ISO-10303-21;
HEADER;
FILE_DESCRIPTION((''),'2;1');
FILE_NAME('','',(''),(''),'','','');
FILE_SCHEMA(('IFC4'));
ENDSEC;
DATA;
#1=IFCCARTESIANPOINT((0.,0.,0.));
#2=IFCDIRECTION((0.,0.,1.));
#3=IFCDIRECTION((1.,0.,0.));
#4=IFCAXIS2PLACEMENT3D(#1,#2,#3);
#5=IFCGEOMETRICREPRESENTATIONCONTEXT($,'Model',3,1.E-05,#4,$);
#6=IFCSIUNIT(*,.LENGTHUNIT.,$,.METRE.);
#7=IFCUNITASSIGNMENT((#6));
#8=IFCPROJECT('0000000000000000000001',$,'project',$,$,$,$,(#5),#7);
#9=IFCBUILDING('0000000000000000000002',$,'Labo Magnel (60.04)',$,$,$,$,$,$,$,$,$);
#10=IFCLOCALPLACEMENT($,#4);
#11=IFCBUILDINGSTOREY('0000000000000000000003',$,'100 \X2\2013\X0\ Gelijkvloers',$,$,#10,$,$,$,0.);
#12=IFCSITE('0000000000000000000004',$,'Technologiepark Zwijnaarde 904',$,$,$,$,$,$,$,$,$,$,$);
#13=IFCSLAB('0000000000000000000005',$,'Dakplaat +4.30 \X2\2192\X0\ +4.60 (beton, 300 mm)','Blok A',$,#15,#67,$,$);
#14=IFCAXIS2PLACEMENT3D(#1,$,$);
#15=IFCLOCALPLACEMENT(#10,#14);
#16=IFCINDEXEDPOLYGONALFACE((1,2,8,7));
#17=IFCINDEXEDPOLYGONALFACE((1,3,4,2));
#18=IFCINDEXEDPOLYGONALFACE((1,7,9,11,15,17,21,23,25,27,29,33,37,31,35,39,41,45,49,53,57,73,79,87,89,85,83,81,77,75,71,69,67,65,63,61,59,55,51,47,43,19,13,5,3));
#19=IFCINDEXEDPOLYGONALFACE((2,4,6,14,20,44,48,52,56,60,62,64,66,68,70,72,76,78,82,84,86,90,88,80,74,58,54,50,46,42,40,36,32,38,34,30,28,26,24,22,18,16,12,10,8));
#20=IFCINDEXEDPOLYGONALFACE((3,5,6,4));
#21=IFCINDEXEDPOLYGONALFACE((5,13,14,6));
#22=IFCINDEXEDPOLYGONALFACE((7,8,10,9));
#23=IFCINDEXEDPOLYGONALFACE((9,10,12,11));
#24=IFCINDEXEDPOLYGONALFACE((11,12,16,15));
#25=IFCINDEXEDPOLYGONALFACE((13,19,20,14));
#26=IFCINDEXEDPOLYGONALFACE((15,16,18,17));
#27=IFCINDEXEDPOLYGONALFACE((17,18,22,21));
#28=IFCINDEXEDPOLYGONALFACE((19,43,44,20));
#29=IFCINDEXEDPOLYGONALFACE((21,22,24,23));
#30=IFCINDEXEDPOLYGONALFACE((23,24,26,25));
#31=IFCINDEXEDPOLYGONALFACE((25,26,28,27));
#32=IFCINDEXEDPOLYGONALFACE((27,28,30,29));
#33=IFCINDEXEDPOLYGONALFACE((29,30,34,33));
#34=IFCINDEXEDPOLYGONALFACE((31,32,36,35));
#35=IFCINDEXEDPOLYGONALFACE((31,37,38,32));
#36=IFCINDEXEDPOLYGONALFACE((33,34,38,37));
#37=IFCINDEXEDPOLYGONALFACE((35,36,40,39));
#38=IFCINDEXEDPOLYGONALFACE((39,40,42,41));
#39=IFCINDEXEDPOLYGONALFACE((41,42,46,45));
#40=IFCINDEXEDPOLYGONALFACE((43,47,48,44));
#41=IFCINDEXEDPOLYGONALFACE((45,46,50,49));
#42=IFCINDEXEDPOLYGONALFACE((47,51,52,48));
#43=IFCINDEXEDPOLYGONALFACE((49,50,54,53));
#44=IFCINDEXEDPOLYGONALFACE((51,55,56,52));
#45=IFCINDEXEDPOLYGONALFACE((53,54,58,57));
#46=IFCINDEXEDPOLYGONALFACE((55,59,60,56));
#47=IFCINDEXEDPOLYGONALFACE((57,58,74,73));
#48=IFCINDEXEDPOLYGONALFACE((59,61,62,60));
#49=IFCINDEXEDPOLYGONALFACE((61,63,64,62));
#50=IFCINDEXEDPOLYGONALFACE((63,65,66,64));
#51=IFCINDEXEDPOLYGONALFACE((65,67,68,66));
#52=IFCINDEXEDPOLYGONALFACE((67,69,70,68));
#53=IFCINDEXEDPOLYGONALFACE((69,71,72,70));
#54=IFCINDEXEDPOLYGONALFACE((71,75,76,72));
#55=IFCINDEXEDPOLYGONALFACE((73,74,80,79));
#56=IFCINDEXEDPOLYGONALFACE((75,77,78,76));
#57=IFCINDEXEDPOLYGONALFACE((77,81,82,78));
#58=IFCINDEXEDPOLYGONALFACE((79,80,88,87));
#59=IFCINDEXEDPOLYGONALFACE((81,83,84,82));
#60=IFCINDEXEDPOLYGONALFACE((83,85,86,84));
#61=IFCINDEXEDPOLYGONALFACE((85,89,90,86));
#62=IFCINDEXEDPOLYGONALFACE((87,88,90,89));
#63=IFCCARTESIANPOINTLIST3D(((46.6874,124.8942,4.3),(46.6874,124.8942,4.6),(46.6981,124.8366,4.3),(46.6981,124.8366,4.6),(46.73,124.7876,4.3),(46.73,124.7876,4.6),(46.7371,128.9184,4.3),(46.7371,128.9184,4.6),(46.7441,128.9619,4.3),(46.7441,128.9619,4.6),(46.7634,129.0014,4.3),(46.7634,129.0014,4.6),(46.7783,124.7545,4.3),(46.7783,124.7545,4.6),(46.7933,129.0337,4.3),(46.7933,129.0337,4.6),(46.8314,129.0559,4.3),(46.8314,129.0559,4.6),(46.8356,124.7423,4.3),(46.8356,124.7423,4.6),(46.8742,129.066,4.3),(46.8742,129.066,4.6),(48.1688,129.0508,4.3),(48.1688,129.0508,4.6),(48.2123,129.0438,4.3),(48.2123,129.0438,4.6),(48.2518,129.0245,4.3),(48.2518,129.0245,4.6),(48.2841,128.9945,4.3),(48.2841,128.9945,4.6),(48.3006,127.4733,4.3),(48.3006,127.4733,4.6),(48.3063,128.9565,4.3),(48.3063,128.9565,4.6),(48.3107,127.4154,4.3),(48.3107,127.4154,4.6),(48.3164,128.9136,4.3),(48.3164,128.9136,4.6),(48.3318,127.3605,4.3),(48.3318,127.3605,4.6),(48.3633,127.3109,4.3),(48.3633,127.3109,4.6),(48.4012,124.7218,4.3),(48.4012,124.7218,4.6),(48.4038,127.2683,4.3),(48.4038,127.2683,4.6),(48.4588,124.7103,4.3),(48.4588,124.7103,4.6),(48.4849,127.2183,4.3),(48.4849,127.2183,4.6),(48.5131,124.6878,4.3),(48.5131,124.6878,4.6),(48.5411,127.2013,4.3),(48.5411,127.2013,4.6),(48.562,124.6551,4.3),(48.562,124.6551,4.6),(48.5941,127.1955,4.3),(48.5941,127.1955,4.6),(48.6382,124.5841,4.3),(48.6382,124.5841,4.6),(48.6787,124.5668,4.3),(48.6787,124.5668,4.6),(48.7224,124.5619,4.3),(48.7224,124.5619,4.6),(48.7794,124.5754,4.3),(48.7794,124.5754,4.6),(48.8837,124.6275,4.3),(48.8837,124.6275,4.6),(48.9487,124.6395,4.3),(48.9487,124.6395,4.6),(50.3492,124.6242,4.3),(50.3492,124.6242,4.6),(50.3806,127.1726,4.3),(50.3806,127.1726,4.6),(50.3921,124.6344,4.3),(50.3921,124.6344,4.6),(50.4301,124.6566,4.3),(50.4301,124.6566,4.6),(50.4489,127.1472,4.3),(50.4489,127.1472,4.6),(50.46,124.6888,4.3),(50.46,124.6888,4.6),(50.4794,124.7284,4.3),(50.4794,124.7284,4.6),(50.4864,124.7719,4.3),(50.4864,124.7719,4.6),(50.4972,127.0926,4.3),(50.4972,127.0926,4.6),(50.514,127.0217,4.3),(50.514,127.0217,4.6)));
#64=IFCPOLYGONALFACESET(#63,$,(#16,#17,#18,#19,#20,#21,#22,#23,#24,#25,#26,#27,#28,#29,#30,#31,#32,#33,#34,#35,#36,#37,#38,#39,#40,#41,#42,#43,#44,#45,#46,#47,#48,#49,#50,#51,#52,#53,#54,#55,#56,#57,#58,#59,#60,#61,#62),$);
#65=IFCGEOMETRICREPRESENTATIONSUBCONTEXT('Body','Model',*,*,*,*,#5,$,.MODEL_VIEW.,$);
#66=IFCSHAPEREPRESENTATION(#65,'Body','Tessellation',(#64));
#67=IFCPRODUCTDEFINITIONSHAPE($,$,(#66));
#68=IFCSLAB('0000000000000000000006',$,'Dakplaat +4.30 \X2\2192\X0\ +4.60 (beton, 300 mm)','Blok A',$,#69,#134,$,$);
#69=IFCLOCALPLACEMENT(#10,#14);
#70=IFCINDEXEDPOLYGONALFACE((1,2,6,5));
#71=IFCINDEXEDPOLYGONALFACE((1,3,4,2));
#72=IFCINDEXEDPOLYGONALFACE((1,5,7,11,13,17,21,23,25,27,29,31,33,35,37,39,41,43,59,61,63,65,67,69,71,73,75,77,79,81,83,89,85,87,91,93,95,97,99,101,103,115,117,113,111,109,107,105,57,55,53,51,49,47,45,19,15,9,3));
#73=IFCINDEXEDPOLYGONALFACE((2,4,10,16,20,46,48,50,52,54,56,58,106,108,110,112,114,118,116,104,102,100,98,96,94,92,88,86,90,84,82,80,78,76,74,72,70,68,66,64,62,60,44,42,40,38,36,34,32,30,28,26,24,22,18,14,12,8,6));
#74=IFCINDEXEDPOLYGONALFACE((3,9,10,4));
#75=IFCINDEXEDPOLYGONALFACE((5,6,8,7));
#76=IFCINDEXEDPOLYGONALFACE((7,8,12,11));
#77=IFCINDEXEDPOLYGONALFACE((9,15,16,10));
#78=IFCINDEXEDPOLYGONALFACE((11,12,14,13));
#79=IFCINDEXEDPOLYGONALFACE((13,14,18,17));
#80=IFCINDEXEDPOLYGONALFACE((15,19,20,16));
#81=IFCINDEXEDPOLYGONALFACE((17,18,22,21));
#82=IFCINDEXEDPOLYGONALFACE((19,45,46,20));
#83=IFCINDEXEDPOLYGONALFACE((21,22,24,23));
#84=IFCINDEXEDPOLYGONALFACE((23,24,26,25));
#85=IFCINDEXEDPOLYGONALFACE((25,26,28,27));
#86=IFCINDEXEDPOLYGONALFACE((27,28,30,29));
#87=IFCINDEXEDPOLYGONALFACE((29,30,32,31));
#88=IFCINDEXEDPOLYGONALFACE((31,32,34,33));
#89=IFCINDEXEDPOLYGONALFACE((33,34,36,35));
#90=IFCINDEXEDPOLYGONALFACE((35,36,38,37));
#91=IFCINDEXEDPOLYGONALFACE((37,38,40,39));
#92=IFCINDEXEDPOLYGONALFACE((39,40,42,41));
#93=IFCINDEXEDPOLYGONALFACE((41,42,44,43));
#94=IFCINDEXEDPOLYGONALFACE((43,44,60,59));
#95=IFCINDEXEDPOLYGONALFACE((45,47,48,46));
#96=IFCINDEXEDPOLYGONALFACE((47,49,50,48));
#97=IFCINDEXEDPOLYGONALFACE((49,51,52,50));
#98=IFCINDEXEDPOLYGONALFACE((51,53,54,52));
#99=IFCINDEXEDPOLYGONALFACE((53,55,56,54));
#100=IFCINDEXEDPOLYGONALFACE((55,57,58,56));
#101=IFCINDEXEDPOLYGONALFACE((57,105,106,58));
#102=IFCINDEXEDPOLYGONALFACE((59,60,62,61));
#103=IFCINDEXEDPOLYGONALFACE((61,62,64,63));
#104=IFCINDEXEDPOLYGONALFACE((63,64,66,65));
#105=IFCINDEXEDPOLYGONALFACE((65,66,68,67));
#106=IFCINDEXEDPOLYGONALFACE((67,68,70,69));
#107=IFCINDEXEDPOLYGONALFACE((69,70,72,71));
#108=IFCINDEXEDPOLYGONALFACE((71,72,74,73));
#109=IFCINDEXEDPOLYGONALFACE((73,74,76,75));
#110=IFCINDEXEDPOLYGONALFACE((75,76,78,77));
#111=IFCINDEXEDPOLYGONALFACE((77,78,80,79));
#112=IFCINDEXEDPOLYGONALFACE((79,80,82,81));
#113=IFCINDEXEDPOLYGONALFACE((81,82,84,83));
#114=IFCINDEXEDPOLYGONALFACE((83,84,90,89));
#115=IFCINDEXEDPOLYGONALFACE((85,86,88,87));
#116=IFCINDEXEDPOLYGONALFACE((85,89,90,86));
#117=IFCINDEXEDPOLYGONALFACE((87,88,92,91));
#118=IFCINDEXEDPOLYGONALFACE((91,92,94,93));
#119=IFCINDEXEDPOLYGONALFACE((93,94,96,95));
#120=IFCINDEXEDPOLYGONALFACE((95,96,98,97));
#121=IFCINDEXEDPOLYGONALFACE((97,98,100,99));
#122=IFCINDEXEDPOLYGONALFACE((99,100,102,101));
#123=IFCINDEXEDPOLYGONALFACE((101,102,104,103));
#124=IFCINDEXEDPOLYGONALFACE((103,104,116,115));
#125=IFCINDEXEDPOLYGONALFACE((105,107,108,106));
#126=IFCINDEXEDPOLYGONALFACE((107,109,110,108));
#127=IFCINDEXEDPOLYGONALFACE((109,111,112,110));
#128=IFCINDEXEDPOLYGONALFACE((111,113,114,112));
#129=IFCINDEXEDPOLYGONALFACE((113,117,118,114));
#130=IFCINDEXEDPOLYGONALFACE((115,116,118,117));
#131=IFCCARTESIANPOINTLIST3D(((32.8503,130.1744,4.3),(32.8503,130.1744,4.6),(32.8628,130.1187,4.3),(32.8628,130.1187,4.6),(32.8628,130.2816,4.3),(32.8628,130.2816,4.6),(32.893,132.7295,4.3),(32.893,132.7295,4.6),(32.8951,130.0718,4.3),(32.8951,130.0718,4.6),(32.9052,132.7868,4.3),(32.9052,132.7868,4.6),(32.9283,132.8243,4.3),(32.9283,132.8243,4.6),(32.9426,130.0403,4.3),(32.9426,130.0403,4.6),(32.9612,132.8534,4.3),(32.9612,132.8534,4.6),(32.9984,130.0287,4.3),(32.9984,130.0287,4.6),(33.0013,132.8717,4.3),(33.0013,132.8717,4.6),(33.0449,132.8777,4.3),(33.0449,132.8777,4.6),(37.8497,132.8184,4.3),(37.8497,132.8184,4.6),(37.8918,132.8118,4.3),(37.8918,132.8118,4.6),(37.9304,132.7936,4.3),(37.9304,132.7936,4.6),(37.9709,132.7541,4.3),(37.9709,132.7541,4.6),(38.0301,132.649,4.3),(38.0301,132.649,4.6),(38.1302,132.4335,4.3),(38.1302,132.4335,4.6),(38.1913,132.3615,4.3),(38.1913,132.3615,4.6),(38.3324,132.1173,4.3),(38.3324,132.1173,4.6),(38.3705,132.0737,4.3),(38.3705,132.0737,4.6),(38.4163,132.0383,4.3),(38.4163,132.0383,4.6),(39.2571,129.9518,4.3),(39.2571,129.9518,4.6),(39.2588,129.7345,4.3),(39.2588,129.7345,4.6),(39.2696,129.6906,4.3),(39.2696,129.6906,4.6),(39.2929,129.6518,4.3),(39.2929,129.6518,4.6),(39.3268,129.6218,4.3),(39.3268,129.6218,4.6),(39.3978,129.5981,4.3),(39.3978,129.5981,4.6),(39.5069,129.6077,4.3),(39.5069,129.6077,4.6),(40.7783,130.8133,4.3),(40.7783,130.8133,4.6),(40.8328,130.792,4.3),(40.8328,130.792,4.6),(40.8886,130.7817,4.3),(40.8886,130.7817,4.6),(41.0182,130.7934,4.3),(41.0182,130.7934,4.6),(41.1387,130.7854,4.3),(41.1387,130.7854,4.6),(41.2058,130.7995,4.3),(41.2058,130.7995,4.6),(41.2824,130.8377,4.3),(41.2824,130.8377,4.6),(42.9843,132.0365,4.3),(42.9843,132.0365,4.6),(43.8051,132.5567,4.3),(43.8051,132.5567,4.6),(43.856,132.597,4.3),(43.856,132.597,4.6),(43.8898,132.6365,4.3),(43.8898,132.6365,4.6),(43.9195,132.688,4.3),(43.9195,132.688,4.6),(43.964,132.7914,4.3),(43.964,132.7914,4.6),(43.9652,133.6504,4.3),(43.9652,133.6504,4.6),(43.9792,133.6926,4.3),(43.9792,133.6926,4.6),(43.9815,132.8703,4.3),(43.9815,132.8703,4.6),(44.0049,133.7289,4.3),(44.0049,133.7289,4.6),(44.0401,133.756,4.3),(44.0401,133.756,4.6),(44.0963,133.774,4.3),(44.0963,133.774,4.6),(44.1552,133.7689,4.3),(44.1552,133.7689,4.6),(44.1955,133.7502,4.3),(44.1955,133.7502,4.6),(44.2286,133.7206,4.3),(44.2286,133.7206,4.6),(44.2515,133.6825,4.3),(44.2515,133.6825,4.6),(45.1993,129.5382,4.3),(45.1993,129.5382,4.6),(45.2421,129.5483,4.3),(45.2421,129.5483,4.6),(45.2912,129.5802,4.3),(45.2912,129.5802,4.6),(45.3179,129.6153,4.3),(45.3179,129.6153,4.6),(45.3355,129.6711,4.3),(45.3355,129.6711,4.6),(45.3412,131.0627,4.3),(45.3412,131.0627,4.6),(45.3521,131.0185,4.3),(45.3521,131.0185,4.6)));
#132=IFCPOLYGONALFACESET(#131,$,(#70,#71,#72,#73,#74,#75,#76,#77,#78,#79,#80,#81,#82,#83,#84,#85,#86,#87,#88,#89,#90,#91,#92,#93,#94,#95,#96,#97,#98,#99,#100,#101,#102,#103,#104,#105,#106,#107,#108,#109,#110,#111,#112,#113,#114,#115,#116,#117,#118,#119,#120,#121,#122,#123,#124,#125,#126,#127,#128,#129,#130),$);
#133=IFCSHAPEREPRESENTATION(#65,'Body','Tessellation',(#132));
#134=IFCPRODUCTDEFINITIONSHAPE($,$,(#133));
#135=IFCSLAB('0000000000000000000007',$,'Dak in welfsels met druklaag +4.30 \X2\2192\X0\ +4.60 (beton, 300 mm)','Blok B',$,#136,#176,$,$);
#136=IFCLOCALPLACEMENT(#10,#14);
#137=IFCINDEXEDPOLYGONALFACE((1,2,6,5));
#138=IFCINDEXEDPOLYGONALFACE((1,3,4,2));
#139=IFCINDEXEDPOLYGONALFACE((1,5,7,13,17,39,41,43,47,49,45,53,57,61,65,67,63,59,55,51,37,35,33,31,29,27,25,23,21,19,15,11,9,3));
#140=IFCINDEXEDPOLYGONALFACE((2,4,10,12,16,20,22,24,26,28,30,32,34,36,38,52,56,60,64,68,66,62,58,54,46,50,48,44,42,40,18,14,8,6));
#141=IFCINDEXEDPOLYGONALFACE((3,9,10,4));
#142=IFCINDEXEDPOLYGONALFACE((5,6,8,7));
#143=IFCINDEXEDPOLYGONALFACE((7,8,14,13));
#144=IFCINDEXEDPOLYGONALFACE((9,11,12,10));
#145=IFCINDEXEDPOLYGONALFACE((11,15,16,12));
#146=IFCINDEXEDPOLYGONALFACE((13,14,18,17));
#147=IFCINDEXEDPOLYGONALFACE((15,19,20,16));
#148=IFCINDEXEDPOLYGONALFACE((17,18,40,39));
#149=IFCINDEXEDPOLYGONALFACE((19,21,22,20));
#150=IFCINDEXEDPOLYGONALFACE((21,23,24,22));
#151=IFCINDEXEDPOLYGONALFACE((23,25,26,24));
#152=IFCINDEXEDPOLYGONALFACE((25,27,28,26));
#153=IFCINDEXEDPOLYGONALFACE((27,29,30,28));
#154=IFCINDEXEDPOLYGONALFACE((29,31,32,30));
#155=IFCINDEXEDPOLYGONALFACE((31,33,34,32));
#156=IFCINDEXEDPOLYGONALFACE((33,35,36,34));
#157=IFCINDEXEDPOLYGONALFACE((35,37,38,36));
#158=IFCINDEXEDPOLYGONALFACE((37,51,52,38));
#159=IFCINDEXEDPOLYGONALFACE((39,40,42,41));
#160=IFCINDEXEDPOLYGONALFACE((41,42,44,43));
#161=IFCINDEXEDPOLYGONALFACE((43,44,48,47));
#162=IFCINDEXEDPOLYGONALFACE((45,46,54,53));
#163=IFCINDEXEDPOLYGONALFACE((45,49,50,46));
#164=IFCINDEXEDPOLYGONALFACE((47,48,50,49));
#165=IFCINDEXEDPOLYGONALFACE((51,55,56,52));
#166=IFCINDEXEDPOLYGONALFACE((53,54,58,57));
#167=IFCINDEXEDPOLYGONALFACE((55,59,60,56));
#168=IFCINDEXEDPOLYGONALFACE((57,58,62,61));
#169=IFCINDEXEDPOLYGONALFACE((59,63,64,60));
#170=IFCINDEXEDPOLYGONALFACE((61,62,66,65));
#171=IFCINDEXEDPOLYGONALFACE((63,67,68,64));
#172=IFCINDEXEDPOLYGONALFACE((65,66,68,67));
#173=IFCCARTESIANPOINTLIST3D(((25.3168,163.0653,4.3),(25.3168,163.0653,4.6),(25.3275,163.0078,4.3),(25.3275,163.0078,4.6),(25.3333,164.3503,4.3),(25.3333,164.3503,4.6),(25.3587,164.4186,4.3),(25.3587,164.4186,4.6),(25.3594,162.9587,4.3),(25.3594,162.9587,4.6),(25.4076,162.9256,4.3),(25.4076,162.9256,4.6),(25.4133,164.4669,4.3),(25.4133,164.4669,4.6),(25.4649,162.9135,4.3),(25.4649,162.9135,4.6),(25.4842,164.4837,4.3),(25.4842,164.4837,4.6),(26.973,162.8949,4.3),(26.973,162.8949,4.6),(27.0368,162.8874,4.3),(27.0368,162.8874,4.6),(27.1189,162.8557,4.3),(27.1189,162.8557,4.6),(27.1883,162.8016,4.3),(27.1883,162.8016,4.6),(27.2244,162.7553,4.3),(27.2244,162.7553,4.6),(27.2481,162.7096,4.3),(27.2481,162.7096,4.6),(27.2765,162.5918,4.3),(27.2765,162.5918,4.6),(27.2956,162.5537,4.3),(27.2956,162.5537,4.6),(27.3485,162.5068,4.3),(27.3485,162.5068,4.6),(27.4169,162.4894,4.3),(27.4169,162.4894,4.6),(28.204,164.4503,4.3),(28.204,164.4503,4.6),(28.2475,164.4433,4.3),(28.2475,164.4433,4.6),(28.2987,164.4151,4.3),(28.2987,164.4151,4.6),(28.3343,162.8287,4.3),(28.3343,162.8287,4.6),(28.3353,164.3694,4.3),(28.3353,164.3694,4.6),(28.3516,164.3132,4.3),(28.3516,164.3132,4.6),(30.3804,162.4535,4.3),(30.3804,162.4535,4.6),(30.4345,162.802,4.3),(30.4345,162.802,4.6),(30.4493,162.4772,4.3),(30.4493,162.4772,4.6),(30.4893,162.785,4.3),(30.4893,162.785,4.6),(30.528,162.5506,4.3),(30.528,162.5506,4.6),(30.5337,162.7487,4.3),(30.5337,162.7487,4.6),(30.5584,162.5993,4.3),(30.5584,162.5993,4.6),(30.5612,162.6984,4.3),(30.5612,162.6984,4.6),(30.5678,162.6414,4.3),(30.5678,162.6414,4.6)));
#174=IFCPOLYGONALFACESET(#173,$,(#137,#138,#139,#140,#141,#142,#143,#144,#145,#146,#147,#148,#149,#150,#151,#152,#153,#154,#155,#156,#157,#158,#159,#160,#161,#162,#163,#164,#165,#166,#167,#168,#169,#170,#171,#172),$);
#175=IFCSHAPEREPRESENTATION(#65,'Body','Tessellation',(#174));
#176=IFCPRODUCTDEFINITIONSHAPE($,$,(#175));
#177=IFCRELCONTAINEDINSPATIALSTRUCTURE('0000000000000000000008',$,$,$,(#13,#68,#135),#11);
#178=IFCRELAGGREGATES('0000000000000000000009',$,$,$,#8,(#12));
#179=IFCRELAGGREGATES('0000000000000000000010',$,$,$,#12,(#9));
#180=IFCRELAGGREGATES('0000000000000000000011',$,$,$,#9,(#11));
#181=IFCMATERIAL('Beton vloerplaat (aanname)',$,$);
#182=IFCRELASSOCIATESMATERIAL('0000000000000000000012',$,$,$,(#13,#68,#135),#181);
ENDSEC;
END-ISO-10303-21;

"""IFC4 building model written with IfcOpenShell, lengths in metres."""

from ifc_helpers import new_model, si_unit, frame, origin, origin_with_axes, place, context, subcontext, project, spatial, polyline, outline, extrude, material, element, save


model = new_model("IFC4")

# Units and contexts
model_context = context("Model", 3, precision=1e-05, world=origin_with_axes())
body_context = subcontext(model_context, "Body", "Model", "MODEL_VIEW")
ifc_project = project(units=[si_unit("LENGTHUNIT", "METRE")], contexts=[model_context])

# Site, building, storey
site = spatial("IfcSite", under=ifc_project, Name="Technologiepark Zwijnaarde 904")
building = spatial("IfcBuilding", under=site, Name="Labo Magnel (60.04)")
storey_placement = place(None, origin_with_axes())
storey = spatial("IfcBuildingStorey", under=building, at=storey_placement, Name="100 – Gelijkvloers", Elevation=0.0)

# Slabs
ifc_material_1 = material(Name="Beton vloerplaat (aanname)")
slab_1_placement = place(storey_placement, frame((0.0, 0.0, 4.3), z_axis=(0.0, 0.0, 1.0), x_axis=(1.0, 0.0, 0.0)))
element("IfcSlab", 1, at=slab_1_placement, inside=storey, material=ifc_material_1, Name="Dakplaat +4.30 → +4.60 (beton, 300 mm)", Description="Blok A", context=body_context, shape_type="SweptSolid", body=[
    extrude(outline(polyline([(46.8356, 124.7423), (46.7783, 124.7545), (46.73, 124.7876), (46.6981, 124.8366), (46.6874, 124.8942), (46.7371, 128.9184), (46.7441, 128.9619), (46.7634, 129.0014), (46.7933, 129.0337), (46.8314, 129.0559), (46.8742, 129.066), (48.1688, 129.0508), (48.2123, 129.0438), (48.2518, 129.0245), (48.2841, 128.9945), (48.3063, 128.9565), (48.3164, 128.9136), (48.3006, 127.4733), (48.3107, 127.4154), (48.3318, 127.3605), (48.3633, 127.3109), (48.4038, 127.2683), (48.4849, 127.2183), (48.5411, 127.2013), (48.5941, 127.1955), (50.3806, 127.1726), (50.4489, 127.1472), (50.4972, 127.0926), (50.514, 127.0217), (50.4864, 124.7719), (50.4794, 124.7284), (50.46, 124.6888), (50.4301, 124.6566), (50.3921, 124.6344), (50.3492, 124.6242), (48.9487, 124.6395), (48.8837, 124.6275), (48.7794, 124.5754), (48.7224, 124.5619), (48.6787, 124.5668), (48.6382, 124.5841), (48.562, 124.6551), (48.5131, 124.6878), (48.4588, 124.7103), (48.4012, 124.7218), (46.8356, 124.7423)])), origin(), (0.0, 0.0, 1.0), 0.3),
])
slab_2_placement = place(storey_placement, frame((0.0, 0.0, 4.3), z_axis=(0.0, 0.0, 1.0), x_axis=(1.0, 0.0, 0.0)))
element("IfcSlab", 2, at=slab_2_placement, inside=storey, material=ifc_material_1, Name="Dakplaat +4.30 → +4.60 (beton, 300 mm)", Description="Blok A", context=body_context, shape_type="SweptSolid", body=[
    extrude(outline(polyline([(32.9984, 130.0287), (32.9426, 130.0403), (32.8951, 130.0718), (32.8628, 130.1187), (32.8503, 130.1744), (32.8628, 130.2816), (32.893, 132.7295), (32.9052, 132.7868), (32.9283, 132.8243), (32.9612, 132.8534), (33.0013, 132.8717), (33.0449, 132.8777), (37.8497, 132.8184), (37.8918, 132.8118), (37.9304, 132.7936), (37.9709, 132.7541), (38.0301, 132.649), (38.1302, 132.4335), (38.1913, 132.3615), (38.3324, 132.1173), (38.3705, 132.0737), (38.4163, 132.0383), (40.7783, 130.8133), (40.8328, 130.792), (40.8886, 130.7817), (41.0182, 130.7934), (41.1387, 130.7854), (41.2058, 130.7995), (41.2824, 130.8377), (42.9843, 132.0365), (43.8051, 132.5567), (43.856, 132.597), (43.8898, 132.6365), (43.9195, 132.688), (43.964, 132.7914), (43.9815, 132.8703), (43.9652, 133.6504), (43.9792, 133.6926), (44.0049, 133.7289), (44.0401, 133.756), (44.0963, 133.774), (44.1552, 133.7689), (44.1955, 133.7502), (44.2286, 133.7206), (44.2515, 133.6825), (45.3412, 131.0627), (45.3521, 131.0185), (45.3355, 129.6711), (45.3179, 129.6153), (45.2912, 129.5802), (45.2421, 129.5483), (45.1993, 129.5382), (39.5069, 129.6077), (39.3978, 129.5981), (39.3268, 129.6218), (39.2929, 129.6518), (39.2696, 129.6906), (39.2588, 129.7345), (39.2571, 129.9518), (32.9984, 130.0287)])), origin(), (0.0, 0.0, 1.0), 0.3),
])
slab_3_placement = place(storey_placement, frame((0.0, 0.0, 4.3), z_axis=(0.0, 0.0, 1.0), x_axis=(1.0, 0.0, 0.0)))
element("IfcSlab", 3, at=slab_3_placement, inside=storey, material=ifc_material_1, Name="Dak in welfsels met druklaag +4.30 → +4.60 (beton, 300 mm)", Description="Blok B", context=body_context, shape_type="SweptSolid", body=[
    extrude(outline(polyline([(25.4649, 162.9135), (25.4076, 162.9256), (25.3594, 162.9587), (25.3275, 163.0078), (25.3168, 163.0653), (25.3333, 164.3503), (25.3587, 164.4186), (25.4133, 164.4669), (25.4842, 164.4837), (28.204, 164.4503), (28.2475, 164.4433), (28.2987, 164.4151), (28.3353, 164.3694), (28.3516, 164.3132), (28.3343, 162.8287), (30.4345, 162.802), (30.4893, 162.785), (30.5337, 162.7487), (30.5612, 162.6984), (30.5678, 162.6414), (30.5584, 162.5993), (30.528, 162.5506), (30.4493, 162.4772), (30.3804, 162.4535), (27.4169, 162.4894), (27.3485, 162.5068), (27.2956, 162.5537), (27.2765, 162.5918), (27.2481, 162.7096), (27.2244, 162.7553), (27.1883, 162.8016), (27.1189, 162.8557), (27.0368, 162.8874), (26.973, 162.8949), (25.4649, 162.9135)])), origin(), (0.0, 0.0, 1.0), 0.3),
])

save(model, "model.ifc")
